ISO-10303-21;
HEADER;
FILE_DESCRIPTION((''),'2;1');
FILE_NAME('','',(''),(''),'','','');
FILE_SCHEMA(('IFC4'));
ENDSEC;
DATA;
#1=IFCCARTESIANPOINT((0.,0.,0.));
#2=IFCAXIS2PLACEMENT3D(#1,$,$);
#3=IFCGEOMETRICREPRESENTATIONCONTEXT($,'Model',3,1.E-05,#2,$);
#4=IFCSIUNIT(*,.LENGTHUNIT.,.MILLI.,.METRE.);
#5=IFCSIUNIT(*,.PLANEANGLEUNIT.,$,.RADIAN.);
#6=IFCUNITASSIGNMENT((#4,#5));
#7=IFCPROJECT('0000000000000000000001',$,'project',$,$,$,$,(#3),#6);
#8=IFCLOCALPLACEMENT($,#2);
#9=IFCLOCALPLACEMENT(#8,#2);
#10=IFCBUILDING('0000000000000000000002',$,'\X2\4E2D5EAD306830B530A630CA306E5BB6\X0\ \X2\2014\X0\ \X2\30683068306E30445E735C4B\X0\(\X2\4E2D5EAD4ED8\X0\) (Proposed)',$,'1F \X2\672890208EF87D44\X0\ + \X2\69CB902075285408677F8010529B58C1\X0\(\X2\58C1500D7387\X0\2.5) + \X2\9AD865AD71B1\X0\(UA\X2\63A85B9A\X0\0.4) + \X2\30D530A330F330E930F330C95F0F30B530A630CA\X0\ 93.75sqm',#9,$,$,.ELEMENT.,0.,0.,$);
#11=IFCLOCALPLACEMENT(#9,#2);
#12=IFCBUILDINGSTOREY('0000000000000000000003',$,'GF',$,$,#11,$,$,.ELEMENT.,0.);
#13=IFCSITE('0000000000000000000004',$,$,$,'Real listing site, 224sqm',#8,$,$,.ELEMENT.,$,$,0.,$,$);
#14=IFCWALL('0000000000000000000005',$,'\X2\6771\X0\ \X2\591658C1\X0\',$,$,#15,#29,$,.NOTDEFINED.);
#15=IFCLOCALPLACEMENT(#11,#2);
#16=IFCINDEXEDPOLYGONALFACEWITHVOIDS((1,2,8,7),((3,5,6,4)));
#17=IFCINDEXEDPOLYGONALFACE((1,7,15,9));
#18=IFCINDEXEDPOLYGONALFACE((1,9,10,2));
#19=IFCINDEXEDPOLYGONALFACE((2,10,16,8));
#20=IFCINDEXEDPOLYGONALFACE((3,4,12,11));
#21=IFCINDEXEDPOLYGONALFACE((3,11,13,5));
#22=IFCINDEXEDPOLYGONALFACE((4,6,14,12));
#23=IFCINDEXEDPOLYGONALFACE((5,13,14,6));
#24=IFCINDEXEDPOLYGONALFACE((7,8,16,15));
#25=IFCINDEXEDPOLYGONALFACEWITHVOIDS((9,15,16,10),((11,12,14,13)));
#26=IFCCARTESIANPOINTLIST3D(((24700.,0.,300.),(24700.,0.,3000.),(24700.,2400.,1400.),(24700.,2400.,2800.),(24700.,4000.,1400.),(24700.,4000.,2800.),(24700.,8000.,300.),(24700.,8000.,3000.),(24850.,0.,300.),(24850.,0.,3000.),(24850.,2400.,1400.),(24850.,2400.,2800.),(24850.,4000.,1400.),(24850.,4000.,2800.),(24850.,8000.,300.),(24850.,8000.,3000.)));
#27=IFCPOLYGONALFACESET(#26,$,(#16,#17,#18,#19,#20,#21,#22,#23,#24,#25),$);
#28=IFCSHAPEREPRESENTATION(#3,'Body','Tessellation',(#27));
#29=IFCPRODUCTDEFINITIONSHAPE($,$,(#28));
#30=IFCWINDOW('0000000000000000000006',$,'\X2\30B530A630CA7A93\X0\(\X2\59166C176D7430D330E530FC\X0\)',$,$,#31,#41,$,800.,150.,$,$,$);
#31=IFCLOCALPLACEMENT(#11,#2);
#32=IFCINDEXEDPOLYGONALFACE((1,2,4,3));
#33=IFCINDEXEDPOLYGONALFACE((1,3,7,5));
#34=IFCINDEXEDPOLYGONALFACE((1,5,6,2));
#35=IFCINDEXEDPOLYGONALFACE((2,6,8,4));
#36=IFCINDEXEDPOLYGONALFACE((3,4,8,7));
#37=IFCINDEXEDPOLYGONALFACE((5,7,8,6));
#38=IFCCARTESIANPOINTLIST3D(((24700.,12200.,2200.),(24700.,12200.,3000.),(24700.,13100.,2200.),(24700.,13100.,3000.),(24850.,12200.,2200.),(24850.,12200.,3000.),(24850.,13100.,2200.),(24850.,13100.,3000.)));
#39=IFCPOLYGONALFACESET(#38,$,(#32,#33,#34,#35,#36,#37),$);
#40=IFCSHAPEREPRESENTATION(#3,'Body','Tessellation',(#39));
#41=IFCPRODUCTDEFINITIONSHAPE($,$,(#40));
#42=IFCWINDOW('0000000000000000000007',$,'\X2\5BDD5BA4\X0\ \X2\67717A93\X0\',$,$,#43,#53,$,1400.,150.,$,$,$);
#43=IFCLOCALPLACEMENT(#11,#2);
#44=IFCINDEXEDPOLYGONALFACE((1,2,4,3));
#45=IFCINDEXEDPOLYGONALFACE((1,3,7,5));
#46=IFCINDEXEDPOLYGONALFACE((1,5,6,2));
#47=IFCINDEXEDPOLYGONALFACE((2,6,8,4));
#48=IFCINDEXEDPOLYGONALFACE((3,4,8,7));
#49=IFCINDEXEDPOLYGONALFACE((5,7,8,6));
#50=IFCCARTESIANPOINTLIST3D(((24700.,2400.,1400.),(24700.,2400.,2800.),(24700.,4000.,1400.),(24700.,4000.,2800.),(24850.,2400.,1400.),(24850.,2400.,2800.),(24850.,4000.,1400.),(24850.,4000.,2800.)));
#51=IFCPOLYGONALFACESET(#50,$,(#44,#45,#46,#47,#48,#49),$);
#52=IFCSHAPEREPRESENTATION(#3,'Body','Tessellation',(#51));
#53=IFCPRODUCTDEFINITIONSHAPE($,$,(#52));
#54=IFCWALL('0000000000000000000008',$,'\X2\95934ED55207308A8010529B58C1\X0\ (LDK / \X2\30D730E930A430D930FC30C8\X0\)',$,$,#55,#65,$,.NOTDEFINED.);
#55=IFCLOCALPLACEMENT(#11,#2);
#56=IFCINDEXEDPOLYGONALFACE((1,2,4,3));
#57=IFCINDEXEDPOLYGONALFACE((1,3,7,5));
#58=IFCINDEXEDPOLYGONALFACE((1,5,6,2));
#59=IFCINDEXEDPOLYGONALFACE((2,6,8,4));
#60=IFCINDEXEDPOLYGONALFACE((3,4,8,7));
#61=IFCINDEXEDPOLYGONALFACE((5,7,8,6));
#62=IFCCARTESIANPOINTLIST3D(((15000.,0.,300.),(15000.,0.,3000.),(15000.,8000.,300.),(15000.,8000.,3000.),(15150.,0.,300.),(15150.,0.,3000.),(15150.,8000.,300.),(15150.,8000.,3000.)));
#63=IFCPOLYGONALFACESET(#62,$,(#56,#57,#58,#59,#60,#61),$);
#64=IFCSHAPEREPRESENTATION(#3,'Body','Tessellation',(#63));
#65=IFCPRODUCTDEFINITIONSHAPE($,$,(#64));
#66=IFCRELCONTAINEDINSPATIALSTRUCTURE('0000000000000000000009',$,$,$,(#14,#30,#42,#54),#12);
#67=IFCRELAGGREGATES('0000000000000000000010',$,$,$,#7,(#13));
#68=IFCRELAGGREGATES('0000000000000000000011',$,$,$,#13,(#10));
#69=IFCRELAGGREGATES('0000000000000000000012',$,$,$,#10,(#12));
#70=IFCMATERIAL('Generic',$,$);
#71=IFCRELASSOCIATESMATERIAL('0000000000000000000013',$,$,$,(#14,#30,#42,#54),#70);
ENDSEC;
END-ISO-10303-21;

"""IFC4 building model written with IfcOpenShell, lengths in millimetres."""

from ifc_helpers import new_model, si_unit, frame, frame_2d, origin, place, context, project, spatial, rectangle, extrude, material, element, fill, save


model = new_model("IFC4")

# Units and contexts
model_context = context("Model", 3, precision=1e-05, world=origin())
ifc_project = project(units=[si_unit("LENGTHUNIT", "METRE", prefix="MILLI"), si_unit("PLANEANGLEUNIT", "RADIAN")], contexts=[model_context])

# Site, building, storey
site_placement = place(None, origin())
site = spatial("IfcSite", under=ifc_project, at=site_placement, ObjectType="Real listing site, 224sqm", CompositionType="ELEMENT", RefElevation=0.0)
building_placement = place(site_placement, origin())
building = spatial("IfcBuilding", under=site, at=building_placement, Name="中庭とサウナの家 — ととのい平屋(中庭付) (Proposed)", ObjectType="1F 木造軸組 + 構造用合板耐力壁(壁倍率2.5) + 高断熱(UA推定0.4) + フィンランド式サウナ 93.75sqm", CompositionType="ELEMENT", ElevationOfRefHeight=0.0, ElevationOfTerrain=0.0)
storey_placement = place(building_placement, origin())
storey = spatial("IfcBuildingStorey", under=building, at=storey_placement, Name="GF", CompositionType="ELEMENT", Elevation=0.0)

# Wall, openings, windows
ifc_material = material(Name="Generic")
wall_1_placement = place(storey_placement, frame((12350.0, 0.0, 150.0)))
wall_1 = element("IfcWall", 1, at=wall_1_placement, inside=storey, material=ifc_material, Name="東 外壁", PredefinedType="NOTDEFINED", context=model_context, shape_type="SweptSolid", body=[
    extrude(rectangle(XDim=150.0, YDim=8000.0, at=frame_2d((75.0, 4000.0))), frame((12350.0, 0.0, 150.0)), (0.0, 0.0, 1.0), 2700.0),
])
opening_1_placement = place(storey_placement, frame((12350.0, 6100.0, 1100.0)))
opening_1 = element("IfcOpeningElement", 2, at=opening_1_placement, cuts=wall_1, PredefinedType="NOTDEFINED", context=model_context, shape_type="SweptSolid", body=[
    extrude(rectangle(XDim=150.0, YDim=900.0, at=frame_2d((75.0, 450.0))), frame((12350.0, 6100.0, 1100.0)), (0.0, 0.0, 1.0), 800.0),
])
opening_2_placement = place(storey_placement, frame((12350.0, 1200.0, 700.0)))
opening_2 = element("IfcOpeningElement", 3, at=opening_2_placement, cuts=wall_1, PredefinedType="NOTDEFINED", context=model_context, shape_type="SweptSolid", body=[
    extrude(rectangle(XDim=150.0, YDim=1600.0, at=frame_2d((75.0, 800.0))), frame((12350.0, 1200.0, 700.0)), (0.0, 0.0, 1.0), 1400.0),
])
window_1_placement = place(storey_placement, frame((12350.0, 6100.0, 1100.0)))
window_1 = element("IfcWindow", 4, at=window_1_placement, inside=storey, material=ifc_material, Name="サウナ窓(外気浴ビュー)", OverallHeight=800.0, OverallWidth=150.0, context=model_context, shape_type="SweptSolid", body=[
    extrude(rectangle(XDim=150.0, YDim=900.0, at=frame_2d((75.0, 450.0))), frame((12350.0, 6100.0, 1100.0)), (0.0, 0.0, 1.0), 800.0),
])
fill(opening_1, window_1)
window_2_placement = place(storey_placement, frame((12350.0, 1200.0, 700.0)))
window_2 = element("IfcWindow", 5, at=window_2_placement, inside=storey, material=ifc_material, Name="寝室 東窓", OverallHeight=1400.0, OverallWidth=150.0, context=model_context, shape_type="SweptSolid", body=[
    extrude(rectangle(XDim=150.0, YDim=1600.0, at=frame_2d((75.0, 800.0))), frame((12350.0, 1200.0, 700.0)), (0.0, 0.0, 1.0), 1400.0),
])
fill(opening_2, window_2)

# Wall
wall_2_placement = place(storey_placement, frame((7500.0, 0.0, 150.0)))
element("IfcWall", 6, at=wall_2_placement, inside=storey, material=ifc_material, Name="間仕切り耐力壁 (LDK / プライベート)", PredefinedType="NOTDEFINED", context=model_context, shape_type="SweptSolid", body=[
    extrude(rectangle(XDim=150.0, YDim=8000.0, at=frame_2d((75.0, 4000.0))), frame((7500.0, 0.0, 150.0)), (0.0, 0.0, 1.0), 2700.0),
])

save(model, "model.ifc")
